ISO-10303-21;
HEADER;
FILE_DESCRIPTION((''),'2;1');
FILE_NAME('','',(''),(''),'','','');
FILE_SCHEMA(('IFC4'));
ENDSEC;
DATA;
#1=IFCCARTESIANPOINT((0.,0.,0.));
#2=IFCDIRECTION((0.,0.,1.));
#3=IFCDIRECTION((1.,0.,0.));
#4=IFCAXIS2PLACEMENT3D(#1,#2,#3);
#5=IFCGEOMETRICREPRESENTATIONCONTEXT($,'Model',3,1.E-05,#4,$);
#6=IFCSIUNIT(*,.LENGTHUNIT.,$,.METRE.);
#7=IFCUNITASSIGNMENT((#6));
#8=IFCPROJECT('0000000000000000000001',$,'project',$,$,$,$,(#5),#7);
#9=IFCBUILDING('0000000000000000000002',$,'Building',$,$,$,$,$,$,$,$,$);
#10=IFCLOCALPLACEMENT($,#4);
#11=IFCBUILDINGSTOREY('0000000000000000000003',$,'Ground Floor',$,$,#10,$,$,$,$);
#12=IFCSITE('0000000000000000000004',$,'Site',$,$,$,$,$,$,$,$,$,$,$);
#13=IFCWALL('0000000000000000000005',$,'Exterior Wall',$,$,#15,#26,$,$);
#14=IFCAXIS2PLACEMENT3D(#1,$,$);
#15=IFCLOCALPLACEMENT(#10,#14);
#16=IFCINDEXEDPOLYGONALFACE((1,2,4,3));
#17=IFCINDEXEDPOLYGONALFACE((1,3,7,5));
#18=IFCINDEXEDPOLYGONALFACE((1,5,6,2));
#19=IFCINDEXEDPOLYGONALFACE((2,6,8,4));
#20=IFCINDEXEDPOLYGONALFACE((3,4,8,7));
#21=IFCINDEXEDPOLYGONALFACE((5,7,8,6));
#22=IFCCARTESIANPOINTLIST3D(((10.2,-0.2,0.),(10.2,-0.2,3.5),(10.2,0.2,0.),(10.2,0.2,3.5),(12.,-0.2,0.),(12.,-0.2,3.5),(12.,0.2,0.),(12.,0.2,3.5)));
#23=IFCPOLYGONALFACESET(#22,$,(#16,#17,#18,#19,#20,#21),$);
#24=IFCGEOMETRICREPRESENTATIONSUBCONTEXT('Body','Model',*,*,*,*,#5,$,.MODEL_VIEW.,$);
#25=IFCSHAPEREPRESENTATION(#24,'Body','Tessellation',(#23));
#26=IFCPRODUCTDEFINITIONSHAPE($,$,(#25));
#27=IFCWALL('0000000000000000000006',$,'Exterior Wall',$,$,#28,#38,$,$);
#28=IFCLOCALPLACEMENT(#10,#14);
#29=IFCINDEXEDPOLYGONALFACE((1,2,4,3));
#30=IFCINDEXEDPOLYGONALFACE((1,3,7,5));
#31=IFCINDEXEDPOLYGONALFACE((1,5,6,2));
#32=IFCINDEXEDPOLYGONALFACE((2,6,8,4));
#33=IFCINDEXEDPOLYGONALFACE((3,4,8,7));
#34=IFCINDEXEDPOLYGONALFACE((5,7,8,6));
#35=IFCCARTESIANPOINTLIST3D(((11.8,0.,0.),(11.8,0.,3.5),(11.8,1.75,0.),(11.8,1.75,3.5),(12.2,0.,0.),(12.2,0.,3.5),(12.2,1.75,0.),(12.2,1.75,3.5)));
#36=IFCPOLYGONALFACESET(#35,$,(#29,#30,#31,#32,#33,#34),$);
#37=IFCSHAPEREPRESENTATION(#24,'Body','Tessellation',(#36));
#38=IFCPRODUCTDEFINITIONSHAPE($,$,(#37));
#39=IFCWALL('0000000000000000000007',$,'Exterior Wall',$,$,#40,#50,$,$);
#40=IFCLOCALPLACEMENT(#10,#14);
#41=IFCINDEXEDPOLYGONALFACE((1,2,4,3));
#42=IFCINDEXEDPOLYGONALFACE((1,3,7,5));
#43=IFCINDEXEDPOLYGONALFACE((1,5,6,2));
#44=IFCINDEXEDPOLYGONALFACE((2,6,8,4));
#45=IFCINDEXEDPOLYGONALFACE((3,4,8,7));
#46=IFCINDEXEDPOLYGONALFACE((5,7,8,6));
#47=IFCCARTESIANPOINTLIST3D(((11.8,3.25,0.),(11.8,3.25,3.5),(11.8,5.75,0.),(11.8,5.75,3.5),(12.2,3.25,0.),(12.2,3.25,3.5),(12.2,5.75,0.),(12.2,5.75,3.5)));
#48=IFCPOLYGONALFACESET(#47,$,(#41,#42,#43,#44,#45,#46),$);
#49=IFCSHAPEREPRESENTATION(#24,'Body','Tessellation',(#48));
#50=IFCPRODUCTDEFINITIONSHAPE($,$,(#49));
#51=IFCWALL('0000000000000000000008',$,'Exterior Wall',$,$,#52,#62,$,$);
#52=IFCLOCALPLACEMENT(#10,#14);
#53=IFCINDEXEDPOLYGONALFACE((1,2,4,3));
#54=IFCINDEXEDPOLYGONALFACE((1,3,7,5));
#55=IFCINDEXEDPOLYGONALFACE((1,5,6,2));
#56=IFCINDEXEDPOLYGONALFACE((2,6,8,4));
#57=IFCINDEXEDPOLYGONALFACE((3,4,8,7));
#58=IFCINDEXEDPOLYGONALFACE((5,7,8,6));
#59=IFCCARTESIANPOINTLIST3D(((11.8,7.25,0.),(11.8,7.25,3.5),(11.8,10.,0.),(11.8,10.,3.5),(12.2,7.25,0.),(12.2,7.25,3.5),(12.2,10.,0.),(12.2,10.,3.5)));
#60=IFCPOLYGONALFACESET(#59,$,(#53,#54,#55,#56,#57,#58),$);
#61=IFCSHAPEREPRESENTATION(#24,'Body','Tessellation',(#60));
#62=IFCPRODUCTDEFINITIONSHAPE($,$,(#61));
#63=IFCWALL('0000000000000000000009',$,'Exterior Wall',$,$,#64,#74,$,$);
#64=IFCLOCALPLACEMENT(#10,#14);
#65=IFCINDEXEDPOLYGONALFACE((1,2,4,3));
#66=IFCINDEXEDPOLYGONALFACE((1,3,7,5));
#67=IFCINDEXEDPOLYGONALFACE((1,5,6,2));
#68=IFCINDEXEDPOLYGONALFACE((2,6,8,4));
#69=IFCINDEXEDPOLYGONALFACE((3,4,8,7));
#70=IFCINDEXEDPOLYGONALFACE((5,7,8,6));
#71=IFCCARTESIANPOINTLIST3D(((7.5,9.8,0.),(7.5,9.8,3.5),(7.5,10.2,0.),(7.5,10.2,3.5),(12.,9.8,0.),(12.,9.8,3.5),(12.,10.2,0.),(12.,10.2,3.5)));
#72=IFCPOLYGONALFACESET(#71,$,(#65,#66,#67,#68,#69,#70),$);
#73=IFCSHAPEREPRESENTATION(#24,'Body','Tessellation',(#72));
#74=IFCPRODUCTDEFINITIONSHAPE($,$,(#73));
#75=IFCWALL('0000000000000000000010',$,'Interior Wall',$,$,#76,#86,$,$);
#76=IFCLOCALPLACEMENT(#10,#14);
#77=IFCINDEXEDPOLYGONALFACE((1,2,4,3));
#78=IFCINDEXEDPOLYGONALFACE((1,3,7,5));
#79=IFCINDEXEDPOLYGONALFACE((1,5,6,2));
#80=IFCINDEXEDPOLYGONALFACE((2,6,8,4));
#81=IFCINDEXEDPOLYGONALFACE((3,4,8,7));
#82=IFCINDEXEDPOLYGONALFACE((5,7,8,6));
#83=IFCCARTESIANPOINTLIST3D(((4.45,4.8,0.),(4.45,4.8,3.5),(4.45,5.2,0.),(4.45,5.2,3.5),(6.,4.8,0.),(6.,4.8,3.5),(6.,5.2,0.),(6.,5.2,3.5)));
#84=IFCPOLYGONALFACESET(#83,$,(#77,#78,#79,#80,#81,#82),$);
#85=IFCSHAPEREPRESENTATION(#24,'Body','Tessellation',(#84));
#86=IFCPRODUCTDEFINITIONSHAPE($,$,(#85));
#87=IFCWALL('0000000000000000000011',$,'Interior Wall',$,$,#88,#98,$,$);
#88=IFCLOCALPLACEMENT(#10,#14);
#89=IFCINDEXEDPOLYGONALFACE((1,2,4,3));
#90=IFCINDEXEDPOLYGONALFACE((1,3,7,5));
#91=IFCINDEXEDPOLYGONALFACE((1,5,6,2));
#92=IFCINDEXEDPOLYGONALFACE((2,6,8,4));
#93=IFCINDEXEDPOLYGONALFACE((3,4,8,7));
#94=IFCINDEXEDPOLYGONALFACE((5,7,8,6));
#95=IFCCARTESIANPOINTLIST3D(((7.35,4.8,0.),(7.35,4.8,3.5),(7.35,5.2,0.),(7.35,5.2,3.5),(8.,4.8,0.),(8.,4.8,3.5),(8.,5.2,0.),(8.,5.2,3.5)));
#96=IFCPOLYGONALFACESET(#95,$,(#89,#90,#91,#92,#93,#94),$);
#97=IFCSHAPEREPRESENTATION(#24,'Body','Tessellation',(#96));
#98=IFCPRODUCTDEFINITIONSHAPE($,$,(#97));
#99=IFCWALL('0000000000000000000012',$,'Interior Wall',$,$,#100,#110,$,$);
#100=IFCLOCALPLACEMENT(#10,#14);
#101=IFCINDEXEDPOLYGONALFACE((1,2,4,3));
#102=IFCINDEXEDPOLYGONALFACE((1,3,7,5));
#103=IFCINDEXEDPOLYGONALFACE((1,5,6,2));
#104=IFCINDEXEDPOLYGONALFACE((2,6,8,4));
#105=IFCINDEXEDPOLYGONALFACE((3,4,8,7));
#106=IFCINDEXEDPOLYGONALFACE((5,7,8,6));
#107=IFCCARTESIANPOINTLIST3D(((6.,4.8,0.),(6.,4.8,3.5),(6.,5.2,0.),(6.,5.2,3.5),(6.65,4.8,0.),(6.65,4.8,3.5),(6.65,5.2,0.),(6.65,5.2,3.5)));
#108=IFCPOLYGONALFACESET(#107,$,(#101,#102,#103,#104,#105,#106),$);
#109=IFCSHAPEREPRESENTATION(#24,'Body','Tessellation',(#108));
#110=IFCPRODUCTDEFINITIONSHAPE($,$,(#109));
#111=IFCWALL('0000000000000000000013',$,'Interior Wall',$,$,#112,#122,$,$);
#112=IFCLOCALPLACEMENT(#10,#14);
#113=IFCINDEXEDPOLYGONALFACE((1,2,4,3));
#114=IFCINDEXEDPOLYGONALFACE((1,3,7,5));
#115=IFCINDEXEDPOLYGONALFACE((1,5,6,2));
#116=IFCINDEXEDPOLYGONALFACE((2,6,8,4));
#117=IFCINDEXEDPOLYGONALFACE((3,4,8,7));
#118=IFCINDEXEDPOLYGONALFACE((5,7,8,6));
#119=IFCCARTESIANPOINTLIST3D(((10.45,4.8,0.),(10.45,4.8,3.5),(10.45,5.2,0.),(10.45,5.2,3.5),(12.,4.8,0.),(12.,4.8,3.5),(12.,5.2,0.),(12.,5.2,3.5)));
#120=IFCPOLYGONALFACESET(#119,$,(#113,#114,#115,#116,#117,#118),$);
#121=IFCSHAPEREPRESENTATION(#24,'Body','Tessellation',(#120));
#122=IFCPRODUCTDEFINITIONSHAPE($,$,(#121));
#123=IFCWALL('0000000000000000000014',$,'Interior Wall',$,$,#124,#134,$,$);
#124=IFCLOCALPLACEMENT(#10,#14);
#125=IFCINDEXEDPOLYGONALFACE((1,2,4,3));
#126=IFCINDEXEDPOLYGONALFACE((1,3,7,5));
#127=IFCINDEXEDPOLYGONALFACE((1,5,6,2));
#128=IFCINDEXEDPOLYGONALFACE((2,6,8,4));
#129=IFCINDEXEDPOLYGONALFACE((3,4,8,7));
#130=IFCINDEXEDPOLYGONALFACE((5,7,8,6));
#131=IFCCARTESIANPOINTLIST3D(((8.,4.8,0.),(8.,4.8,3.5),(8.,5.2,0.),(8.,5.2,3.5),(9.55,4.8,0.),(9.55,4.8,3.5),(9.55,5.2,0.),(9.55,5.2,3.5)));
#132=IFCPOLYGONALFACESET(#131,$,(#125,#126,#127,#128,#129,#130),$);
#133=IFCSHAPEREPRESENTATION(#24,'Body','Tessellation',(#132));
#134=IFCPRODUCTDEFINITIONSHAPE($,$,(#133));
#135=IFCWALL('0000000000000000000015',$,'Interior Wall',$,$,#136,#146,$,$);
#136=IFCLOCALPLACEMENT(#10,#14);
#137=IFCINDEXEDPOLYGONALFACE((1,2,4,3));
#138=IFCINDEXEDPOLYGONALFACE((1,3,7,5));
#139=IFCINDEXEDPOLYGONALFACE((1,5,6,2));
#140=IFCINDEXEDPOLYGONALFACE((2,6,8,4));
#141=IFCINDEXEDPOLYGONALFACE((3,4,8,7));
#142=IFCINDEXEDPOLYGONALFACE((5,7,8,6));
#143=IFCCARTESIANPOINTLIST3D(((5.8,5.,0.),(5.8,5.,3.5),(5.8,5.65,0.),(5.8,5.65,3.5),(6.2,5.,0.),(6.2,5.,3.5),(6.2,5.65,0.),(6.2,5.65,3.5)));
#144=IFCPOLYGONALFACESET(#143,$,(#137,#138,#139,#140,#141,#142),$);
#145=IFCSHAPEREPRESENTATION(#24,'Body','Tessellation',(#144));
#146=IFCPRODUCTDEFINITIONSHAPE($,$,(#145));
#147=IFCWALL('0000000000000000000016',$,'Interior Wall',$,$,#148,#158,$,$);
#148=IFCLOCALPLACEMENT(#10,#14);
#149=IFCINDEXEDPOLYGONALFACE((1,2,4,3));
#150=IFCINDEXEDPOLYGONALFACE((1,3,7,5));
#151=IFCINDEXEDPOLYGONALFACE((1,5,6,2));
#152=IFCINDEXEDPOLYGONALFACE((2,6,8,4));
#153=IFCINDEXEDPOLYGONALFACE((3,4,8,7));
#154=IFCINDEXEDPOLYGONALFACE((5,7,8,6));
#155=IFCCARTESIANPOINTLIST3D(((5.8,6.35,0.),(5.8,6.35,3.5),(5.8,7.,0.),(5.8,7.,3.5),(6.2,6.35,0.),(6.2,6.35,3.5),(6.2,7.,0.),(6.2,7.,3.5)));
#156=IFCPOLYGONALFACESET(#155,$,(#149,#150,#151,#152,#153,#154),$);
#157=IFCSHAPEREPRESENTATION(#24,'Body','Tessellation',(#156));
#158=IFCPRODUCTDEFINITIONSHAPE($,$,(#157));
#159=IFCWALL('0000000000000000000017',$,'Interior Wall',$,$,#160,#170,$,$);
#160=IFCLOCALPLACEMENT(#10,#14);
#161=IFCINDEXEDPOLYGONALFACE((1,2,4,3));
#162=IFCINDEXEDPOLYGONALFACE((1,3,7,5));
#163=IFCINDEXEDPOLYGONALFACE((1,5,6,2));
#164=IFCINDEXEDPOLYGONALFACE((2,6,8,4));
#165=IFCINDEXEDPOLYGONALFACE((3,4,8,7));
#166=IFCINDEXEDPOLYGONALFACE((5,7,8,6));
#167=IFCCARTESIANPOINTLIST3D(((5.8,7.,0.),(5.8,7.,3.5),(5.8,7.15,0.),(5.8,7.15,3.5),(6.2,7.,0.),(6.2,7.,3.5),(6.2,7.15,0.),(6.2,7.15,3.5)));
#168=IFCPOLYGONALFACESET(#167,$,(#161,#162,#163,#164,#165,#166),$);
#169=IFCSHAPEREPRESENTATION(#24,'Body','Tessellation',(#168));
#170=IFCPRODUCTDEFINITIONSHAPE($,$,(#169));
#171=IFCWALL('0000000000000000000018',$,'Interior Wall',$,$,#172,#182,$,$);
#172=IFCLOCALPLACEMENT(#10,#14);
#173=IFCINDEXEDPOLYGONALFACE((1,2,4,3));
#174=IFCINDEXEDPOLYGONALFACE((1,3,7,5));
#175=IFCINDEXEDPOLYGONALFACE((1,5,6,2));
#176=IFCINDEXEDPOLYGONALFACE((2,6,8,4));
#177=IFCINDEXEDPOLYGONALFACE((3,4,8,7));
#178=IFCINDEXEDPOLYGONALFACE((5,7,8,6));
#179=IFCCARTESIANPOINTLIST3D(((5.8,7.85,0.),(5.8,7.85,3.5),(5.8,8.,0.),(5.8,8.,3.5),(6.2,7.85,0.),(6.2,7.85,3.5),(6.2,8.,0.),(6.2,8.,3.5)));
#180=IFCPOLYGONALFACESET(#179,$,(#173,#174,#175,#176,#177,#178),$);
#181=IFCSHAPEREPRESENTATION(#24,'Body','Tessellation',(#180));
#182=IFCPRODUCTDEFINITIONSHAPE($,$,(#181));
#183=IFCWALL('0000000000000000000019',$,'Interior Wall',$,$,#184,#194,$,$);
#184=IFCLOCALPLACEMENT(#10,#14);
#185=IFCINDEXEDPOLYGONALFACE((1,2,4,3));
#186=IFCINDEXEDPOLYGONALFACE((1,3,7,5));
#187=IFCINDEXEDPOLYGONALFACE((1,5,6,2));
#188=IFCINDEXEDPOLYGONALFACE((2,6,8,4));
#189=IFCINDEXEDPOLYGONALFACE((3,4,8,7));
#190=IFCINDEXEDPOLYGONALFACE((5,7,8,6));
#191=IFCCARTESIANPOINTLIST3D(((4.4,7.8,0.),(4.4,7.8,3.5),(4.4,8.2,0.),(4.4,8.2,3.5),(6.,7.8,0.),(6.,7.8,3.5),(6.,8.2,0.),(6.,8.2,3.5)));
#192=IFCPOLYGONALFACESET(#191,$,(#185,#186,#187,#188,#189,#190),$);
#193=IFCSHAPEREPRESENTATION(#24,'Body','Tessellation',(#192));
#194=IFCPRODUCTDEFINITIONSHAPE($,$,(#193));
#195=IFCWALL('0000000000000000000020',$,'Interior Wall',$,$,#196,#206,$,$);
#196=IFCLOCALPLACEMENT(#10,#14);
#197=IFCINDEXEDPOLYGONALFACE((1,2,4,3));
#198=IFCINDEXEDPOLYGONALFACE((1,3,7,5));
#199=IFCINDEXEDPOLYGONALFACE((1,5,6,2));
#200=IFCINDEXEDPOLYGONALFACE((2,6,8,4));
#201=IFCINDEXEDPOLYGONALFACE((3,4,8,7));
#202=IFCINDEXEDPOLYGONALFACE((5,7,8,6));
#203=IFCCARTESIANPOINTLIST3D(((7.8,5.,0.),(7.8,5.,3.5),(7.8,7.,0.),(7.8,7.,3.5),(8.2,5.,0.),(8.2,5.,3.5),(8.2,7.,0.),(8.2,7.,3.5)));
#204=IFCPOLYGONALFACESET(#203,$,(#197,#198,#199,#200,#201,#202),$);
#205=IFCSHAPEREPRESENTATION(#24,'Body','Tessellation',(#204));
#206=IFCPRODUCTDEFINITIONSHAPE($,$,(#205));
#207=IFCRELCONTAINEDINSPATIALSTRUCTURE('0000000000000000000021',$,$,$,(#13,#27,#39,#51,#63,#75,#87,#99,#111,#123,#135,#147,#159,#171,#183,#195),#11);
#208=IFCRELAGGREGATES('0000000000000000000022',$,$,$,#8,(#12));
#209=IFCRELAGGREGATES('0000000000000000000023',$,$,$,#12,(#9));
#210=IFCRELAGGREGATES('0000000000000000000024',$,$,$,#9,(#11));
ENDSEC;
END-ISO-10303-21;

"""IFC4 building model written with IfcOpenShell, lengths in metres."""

from ifc_helpers import new_model, si_unit, frame, origin_with_axes, place, context, subcontext, project, spatial, indexed_curve, outline, extrude, element, save


model = new_model("IFC4")

# Units and contexts
model_context = context("Model", 3, precision=1e-05, world=origin_with_axes())
body_context = subcontext(model_context, "Body", "Model", "MODEL_VIEW")
ifc_project = project(units=[si_unit("LENGTHUNIT", "METRE")], contexts=[model_context])

# Site, building, storey
site = spatial("IfcSite", under=ifc_project, Name="Site")
building = spatial("IfcBuilding", under=site, Name="Building")
storey_placement = place(None, origin_with_axes())
storey = spatial("IfcBuildingStorey", under=building, at=storey_placement, Name="Ground Floor")

# Walls
wall_1_placement = place(storey_placement, frame((10.2, 0.0, 0.0), z_axis=(0.0, 0.0, 1.0), x_axis=(1.0, 0.0, 0.0)))
element("IfcWall", 1, at=wall_1_placement, inside=storey, Name="Exterior Wall", context=body_context, shape_type="SweptSolid", body=[
    extrude(outline(indexed_curve([(0.0, 0.0), (0.0, 0.4), (1.8, 0.4), (1.8, 0.0), (0.0, 0.0)], self_intersect=False)), frame((0.0, -0.2, 0.0), z_axis=(0.0, 0.0, 1.0), x_axis=(1.0, 0.0, 0.0)), (0.0, 0.0, 1.0), 3.5),
])
wall_2_placement = place(storey_placement, frame((12.0, 0.0, 0.0), z_axis=(0.0, 0.0, 1.0), x_axis=(0.0, 1.0, 0.0)))
element("IfcWall", 2, at=wall_2_placement, inside=storey, Name="Exterior Wall", context=body_context, shape_type="SweptSolid", body=[
    extrude(outline(indexed_curve([(0.0, 0.0), (0.0, 0.4), (1.75, 0.4), (1.75, 0.0), (0.0, 0.0)], self_intersect=False)), frame((0.0, -0.2, 0.0), z_axis=(0.0, 0.0, 1.0), x_axis=(1.0, 0.0, 0.0)), (0.0, 0.0, 1.0), 3.5),
])
wall_3_placement = place(storey_placement, frame((12.0, 3.25, 0.0), z_axis=(0.0, 0.0, 1.0), x_axis=(0.0, 1.0, 0.0)))
element("IfcWall", 3, at=wall_3_placement, inside=storey, Name="Exterior Wall", context=body_context, shape_type="SweptSolid", body=[
    extrude(outline(indexed_curve([(0.0, 0.0), (0.0, 0.4), (2.5, 0.4), (2.5, 0.0), (0.0, 0.0)], self_intersect=False)), frame((0.0, -0.2, 0.0), z_axis=(0.0, 0.0, 1.0), x_axis=(1.0, 0.0, 0.0)), (0.0, 0.0, 1.0), 3.5),
])
wall_4_placement = place(storey_placement, frame((12.0, 7.25, 0.0), z_axis=(0.0, 0.0, 1.0), x_axis=(0.0, 1.0, 0.0)))
element("IfcWall", 4, at=wall_4_placement, inside=storey, Name="Exterior Wall", context=body_context, shape_type="SweptSolid", body=[
    extrude(outline(indexed_curve([(0.0, 0.0), (0.0, 0.4), (2.75, 0.4), (2.75, 0.0), (0.0, 0.0)], self_intersect=False)), frame((0.0, -0.2, 0.0), z_axis=(0.0, 0.0, 1.0), x_axis=(1.0, 0.0, 0.0)), (0.0, 0.0, 1.0), 3.5),
])
wall_5_placement = place(storey_placement, frame((12.0, 10.0, 0.0), z_axis=(0.0, 0.0, 1.0), x_axis=(-1.0, 0.0, 0.0)))
element("IfcWall", 5, at=wall_5_placement, inside=storey, Name="Exterior Wall", context=body_context, shape_type="SweptSolid", body=[
    extrude(outline(indexed_curve([(0.0, 0.0), (0.0, 0.4), (4.5, 0.4), (4.5, 0.0), (0.0, 0.0)], self_intersect=False)), frame((0.0, -0.2, 0.0), z_axis=(0.0, 0.0, 1.0), x_axis=(1.0, 0.0, 0.0)), (0.0, 0.0, 1.0), 3.5),
])
wall_6_placement = place(storey_placement, frame((6.0, 5.0, 0.0), z_axis=(0.0, 0.0, 1.0), x_axis=(-1.0, 0.0, 0.0)))
element("IfcWall", 6, at=wall_6_placement, inside=storey, Name="Interior Wall", context=body_context, shape_type="SweptSolid", body=[
    extrude(outline(indexed_curve([(0.0, 0.0), (0.0, 0.4), (1.55, 0.4), (1.55, 0.0), (0.0, 0.0)], self_intersect=False)), frame((0.0, -0.2, 0.0), z_axis=(0.0, 0.0, 1.0), x_axis=(1.0, 0.0, 0.0)), (0.0, 0.0, 1.0), 3.5),
])
for number, where, z_axis, x_axis, name in (
    (7, (8.0, 5.0, 0.0), (0.0, 0.0, 1.0), (-1.0, 0.0, 0.0), "Interior Wall"),
    (8, (6.65, 5.0, 0.0), (0.0, 0.0, 1.0), (-1.0, 0.0, 0.0), "Interior Wall"),
):
    element("IfcWall", number, at=place(storey_placement, frame(where, z_axis=z_axis, x_axis=x_axis)), inside=storey, Name=name, context=body_context, shape_type="SweptSolid", body=[
        extrude(outline(indexed_curve([(0.0, 0.0), (0.0, 0.4), (0.65, 0.4), (0.65, 0.0), (0.0, 0.0)], self_intersect=False)), frame((0.0, -0.2, 0.0), z_axis=(0.0, 0.0, 1.0), x_axis=(1.0, 0.0, 0.0)), (0.0, 0.0, 1.0), 3.5),
    ])
for number, where, z_axis, x_axis, name in (
    (9, (12.0, 5.0, 0.0), (0.0, 0.0, 1.0), (-1.0, 0.0, 0.0), "Interior Wall"),
    (10, (9.55, 5.0, 0.0), (0.0, 0.0, 1.0), (-1.0, 0.0, 0.0), "Interior Wall"),
):
    element("IfcWall", number, at=place(storey_placement, frame(where, z_axis=z_axis, x_axis=x_axis)), inside=storey, Name=name, context=body_context, shape_type="SweptSolid", body=[
        extrude(outline(indexed_curve([(0.0, 0.0), (0.0, 0.4), (1.55, 0.4), (1.55, 0.0), (0.0, 0.0)], self_intersect=False)), frame((0.0, -0.2, 0.0), z_axis=(0.0, 0.0, 1.0), x_axis=(1.0, 0.0, 0.0)), (0.0, 0.0, 1.0), 3.5),
    ])
for number, where, z_axis, x_axis, name in (
    (11, (6.0, 5.0, 0.0), (0.0, 0.0, 1.0), (0.0, 1.0, 0.0), "Interior Wall"),
    (12, (6.0, 6.35, 0.0), (0.0, 0.0, 1.0), (0.0, 1.0, 0.0), "Interior Wall"),
):
    element("IfcWall", number, at=place(storey_placement, frame(where, z_axis=z_axis, x_axis=x_axis)), inside=storey, Name=name, context=body_context, shape_type="SweptSolid", body=[
        extrude(outline(indexed_curve([(0.0, 0.0), (0.0, 0.4), (0.65, 0.4), (0.65, 0.0), (0.0, 0.0)], self_intersect=False)), frame((0.0, -0.2, 0.0), z_axis=(0.0, 0.0, 1.0), x_axis=(1.0, 0.0, 0.0)), (0.0, 0.0, 1.0), 3.5),
    ])
for number, where, z_axis, x_axis, name in (
    (13, (6.0, 7.0, 0.0), (0.0, 0.0, 1.0), (0.0, 1.0, 0.0), "Interior Wall"),
    (14, (6.0, 7.85, 0.0), (0.0, 0.0, 1.0), (0.0, 1.0, 0.0), "Interior Wall"),
):
    element("IfcWall", number, at=place(storey_placement, frame(where, z_axis=z_axis, x_axis=x_axis)), inside=storey, Name=name, context=body_context, shape_type="SweptSolid", body=[
        extrude(outline(indexed_curve([(0.0, 0.0), (0.0, 0.4), (0.15, 0.4), (0.15, 0.0), (0.0, 0.0)], self_intersect=False)), frame((0.0, -0.2, 0.0), z_axis=(0.0, 0.0, 1.0), x_axis=(1.0, 0.0, 0.0)), (0.0, 0.0, 1.0), 3.5),
    ])
wall_7_placement = place(storey_placement, frame((6.0, 8.0, 0.0), z_axis=(0.0, 0.0, 1.0), x_axis=(-1.0, 0.0, 0.0)))
element("IfcWall", 15, at=wall_7_placement, inside=storey, Name="Interior Wall", context=body_context, shape_type="SweptSolid", body=[
    extrude(outline(indexed_curve([(0.0, 0.0), (0.0, 0.4), (1.6, 0.4), (1.6, 0.0), (0.0, 0.0)], self_intersect=False)), frame((0.0, -0.2, 0.0), z_axis=(0.0, 0.0, 1.0), x_axis=(1.0, 0.0, 0.0)), (0.0, 0.0, 1.0), 3.5),
])
for number, where, z_axis, x_axis, name in (
    (16, (8.0, 5.0, 0.0), (0.0, 0.0, 1.0), (0.0, 1.0, 0.0), "Interior Wall"),
):
    element("IfcWall", number, at=place(storey_placement, frame(where, z_axis=z_axis, x_axis=x_axis)), inside=storey, Name=name, context=body_context, shape_type="SweptSolid", body=[
        extrude(outline(indexed_curve([(0.0, 0.0), (0.0, 0.4), (2.0, 0.4), (2.0, 0.0), (0.0, 0.0)], self_intersect=False)), frame((0.0, -0.2, 0.0), z_axis=(0.0, 0.0, 1.0), x_axis=(1.0, 0.0, 0.0)), (0.0, 0.0, 1.0), 3.5),
    ])

save(model, "model.ifc")
